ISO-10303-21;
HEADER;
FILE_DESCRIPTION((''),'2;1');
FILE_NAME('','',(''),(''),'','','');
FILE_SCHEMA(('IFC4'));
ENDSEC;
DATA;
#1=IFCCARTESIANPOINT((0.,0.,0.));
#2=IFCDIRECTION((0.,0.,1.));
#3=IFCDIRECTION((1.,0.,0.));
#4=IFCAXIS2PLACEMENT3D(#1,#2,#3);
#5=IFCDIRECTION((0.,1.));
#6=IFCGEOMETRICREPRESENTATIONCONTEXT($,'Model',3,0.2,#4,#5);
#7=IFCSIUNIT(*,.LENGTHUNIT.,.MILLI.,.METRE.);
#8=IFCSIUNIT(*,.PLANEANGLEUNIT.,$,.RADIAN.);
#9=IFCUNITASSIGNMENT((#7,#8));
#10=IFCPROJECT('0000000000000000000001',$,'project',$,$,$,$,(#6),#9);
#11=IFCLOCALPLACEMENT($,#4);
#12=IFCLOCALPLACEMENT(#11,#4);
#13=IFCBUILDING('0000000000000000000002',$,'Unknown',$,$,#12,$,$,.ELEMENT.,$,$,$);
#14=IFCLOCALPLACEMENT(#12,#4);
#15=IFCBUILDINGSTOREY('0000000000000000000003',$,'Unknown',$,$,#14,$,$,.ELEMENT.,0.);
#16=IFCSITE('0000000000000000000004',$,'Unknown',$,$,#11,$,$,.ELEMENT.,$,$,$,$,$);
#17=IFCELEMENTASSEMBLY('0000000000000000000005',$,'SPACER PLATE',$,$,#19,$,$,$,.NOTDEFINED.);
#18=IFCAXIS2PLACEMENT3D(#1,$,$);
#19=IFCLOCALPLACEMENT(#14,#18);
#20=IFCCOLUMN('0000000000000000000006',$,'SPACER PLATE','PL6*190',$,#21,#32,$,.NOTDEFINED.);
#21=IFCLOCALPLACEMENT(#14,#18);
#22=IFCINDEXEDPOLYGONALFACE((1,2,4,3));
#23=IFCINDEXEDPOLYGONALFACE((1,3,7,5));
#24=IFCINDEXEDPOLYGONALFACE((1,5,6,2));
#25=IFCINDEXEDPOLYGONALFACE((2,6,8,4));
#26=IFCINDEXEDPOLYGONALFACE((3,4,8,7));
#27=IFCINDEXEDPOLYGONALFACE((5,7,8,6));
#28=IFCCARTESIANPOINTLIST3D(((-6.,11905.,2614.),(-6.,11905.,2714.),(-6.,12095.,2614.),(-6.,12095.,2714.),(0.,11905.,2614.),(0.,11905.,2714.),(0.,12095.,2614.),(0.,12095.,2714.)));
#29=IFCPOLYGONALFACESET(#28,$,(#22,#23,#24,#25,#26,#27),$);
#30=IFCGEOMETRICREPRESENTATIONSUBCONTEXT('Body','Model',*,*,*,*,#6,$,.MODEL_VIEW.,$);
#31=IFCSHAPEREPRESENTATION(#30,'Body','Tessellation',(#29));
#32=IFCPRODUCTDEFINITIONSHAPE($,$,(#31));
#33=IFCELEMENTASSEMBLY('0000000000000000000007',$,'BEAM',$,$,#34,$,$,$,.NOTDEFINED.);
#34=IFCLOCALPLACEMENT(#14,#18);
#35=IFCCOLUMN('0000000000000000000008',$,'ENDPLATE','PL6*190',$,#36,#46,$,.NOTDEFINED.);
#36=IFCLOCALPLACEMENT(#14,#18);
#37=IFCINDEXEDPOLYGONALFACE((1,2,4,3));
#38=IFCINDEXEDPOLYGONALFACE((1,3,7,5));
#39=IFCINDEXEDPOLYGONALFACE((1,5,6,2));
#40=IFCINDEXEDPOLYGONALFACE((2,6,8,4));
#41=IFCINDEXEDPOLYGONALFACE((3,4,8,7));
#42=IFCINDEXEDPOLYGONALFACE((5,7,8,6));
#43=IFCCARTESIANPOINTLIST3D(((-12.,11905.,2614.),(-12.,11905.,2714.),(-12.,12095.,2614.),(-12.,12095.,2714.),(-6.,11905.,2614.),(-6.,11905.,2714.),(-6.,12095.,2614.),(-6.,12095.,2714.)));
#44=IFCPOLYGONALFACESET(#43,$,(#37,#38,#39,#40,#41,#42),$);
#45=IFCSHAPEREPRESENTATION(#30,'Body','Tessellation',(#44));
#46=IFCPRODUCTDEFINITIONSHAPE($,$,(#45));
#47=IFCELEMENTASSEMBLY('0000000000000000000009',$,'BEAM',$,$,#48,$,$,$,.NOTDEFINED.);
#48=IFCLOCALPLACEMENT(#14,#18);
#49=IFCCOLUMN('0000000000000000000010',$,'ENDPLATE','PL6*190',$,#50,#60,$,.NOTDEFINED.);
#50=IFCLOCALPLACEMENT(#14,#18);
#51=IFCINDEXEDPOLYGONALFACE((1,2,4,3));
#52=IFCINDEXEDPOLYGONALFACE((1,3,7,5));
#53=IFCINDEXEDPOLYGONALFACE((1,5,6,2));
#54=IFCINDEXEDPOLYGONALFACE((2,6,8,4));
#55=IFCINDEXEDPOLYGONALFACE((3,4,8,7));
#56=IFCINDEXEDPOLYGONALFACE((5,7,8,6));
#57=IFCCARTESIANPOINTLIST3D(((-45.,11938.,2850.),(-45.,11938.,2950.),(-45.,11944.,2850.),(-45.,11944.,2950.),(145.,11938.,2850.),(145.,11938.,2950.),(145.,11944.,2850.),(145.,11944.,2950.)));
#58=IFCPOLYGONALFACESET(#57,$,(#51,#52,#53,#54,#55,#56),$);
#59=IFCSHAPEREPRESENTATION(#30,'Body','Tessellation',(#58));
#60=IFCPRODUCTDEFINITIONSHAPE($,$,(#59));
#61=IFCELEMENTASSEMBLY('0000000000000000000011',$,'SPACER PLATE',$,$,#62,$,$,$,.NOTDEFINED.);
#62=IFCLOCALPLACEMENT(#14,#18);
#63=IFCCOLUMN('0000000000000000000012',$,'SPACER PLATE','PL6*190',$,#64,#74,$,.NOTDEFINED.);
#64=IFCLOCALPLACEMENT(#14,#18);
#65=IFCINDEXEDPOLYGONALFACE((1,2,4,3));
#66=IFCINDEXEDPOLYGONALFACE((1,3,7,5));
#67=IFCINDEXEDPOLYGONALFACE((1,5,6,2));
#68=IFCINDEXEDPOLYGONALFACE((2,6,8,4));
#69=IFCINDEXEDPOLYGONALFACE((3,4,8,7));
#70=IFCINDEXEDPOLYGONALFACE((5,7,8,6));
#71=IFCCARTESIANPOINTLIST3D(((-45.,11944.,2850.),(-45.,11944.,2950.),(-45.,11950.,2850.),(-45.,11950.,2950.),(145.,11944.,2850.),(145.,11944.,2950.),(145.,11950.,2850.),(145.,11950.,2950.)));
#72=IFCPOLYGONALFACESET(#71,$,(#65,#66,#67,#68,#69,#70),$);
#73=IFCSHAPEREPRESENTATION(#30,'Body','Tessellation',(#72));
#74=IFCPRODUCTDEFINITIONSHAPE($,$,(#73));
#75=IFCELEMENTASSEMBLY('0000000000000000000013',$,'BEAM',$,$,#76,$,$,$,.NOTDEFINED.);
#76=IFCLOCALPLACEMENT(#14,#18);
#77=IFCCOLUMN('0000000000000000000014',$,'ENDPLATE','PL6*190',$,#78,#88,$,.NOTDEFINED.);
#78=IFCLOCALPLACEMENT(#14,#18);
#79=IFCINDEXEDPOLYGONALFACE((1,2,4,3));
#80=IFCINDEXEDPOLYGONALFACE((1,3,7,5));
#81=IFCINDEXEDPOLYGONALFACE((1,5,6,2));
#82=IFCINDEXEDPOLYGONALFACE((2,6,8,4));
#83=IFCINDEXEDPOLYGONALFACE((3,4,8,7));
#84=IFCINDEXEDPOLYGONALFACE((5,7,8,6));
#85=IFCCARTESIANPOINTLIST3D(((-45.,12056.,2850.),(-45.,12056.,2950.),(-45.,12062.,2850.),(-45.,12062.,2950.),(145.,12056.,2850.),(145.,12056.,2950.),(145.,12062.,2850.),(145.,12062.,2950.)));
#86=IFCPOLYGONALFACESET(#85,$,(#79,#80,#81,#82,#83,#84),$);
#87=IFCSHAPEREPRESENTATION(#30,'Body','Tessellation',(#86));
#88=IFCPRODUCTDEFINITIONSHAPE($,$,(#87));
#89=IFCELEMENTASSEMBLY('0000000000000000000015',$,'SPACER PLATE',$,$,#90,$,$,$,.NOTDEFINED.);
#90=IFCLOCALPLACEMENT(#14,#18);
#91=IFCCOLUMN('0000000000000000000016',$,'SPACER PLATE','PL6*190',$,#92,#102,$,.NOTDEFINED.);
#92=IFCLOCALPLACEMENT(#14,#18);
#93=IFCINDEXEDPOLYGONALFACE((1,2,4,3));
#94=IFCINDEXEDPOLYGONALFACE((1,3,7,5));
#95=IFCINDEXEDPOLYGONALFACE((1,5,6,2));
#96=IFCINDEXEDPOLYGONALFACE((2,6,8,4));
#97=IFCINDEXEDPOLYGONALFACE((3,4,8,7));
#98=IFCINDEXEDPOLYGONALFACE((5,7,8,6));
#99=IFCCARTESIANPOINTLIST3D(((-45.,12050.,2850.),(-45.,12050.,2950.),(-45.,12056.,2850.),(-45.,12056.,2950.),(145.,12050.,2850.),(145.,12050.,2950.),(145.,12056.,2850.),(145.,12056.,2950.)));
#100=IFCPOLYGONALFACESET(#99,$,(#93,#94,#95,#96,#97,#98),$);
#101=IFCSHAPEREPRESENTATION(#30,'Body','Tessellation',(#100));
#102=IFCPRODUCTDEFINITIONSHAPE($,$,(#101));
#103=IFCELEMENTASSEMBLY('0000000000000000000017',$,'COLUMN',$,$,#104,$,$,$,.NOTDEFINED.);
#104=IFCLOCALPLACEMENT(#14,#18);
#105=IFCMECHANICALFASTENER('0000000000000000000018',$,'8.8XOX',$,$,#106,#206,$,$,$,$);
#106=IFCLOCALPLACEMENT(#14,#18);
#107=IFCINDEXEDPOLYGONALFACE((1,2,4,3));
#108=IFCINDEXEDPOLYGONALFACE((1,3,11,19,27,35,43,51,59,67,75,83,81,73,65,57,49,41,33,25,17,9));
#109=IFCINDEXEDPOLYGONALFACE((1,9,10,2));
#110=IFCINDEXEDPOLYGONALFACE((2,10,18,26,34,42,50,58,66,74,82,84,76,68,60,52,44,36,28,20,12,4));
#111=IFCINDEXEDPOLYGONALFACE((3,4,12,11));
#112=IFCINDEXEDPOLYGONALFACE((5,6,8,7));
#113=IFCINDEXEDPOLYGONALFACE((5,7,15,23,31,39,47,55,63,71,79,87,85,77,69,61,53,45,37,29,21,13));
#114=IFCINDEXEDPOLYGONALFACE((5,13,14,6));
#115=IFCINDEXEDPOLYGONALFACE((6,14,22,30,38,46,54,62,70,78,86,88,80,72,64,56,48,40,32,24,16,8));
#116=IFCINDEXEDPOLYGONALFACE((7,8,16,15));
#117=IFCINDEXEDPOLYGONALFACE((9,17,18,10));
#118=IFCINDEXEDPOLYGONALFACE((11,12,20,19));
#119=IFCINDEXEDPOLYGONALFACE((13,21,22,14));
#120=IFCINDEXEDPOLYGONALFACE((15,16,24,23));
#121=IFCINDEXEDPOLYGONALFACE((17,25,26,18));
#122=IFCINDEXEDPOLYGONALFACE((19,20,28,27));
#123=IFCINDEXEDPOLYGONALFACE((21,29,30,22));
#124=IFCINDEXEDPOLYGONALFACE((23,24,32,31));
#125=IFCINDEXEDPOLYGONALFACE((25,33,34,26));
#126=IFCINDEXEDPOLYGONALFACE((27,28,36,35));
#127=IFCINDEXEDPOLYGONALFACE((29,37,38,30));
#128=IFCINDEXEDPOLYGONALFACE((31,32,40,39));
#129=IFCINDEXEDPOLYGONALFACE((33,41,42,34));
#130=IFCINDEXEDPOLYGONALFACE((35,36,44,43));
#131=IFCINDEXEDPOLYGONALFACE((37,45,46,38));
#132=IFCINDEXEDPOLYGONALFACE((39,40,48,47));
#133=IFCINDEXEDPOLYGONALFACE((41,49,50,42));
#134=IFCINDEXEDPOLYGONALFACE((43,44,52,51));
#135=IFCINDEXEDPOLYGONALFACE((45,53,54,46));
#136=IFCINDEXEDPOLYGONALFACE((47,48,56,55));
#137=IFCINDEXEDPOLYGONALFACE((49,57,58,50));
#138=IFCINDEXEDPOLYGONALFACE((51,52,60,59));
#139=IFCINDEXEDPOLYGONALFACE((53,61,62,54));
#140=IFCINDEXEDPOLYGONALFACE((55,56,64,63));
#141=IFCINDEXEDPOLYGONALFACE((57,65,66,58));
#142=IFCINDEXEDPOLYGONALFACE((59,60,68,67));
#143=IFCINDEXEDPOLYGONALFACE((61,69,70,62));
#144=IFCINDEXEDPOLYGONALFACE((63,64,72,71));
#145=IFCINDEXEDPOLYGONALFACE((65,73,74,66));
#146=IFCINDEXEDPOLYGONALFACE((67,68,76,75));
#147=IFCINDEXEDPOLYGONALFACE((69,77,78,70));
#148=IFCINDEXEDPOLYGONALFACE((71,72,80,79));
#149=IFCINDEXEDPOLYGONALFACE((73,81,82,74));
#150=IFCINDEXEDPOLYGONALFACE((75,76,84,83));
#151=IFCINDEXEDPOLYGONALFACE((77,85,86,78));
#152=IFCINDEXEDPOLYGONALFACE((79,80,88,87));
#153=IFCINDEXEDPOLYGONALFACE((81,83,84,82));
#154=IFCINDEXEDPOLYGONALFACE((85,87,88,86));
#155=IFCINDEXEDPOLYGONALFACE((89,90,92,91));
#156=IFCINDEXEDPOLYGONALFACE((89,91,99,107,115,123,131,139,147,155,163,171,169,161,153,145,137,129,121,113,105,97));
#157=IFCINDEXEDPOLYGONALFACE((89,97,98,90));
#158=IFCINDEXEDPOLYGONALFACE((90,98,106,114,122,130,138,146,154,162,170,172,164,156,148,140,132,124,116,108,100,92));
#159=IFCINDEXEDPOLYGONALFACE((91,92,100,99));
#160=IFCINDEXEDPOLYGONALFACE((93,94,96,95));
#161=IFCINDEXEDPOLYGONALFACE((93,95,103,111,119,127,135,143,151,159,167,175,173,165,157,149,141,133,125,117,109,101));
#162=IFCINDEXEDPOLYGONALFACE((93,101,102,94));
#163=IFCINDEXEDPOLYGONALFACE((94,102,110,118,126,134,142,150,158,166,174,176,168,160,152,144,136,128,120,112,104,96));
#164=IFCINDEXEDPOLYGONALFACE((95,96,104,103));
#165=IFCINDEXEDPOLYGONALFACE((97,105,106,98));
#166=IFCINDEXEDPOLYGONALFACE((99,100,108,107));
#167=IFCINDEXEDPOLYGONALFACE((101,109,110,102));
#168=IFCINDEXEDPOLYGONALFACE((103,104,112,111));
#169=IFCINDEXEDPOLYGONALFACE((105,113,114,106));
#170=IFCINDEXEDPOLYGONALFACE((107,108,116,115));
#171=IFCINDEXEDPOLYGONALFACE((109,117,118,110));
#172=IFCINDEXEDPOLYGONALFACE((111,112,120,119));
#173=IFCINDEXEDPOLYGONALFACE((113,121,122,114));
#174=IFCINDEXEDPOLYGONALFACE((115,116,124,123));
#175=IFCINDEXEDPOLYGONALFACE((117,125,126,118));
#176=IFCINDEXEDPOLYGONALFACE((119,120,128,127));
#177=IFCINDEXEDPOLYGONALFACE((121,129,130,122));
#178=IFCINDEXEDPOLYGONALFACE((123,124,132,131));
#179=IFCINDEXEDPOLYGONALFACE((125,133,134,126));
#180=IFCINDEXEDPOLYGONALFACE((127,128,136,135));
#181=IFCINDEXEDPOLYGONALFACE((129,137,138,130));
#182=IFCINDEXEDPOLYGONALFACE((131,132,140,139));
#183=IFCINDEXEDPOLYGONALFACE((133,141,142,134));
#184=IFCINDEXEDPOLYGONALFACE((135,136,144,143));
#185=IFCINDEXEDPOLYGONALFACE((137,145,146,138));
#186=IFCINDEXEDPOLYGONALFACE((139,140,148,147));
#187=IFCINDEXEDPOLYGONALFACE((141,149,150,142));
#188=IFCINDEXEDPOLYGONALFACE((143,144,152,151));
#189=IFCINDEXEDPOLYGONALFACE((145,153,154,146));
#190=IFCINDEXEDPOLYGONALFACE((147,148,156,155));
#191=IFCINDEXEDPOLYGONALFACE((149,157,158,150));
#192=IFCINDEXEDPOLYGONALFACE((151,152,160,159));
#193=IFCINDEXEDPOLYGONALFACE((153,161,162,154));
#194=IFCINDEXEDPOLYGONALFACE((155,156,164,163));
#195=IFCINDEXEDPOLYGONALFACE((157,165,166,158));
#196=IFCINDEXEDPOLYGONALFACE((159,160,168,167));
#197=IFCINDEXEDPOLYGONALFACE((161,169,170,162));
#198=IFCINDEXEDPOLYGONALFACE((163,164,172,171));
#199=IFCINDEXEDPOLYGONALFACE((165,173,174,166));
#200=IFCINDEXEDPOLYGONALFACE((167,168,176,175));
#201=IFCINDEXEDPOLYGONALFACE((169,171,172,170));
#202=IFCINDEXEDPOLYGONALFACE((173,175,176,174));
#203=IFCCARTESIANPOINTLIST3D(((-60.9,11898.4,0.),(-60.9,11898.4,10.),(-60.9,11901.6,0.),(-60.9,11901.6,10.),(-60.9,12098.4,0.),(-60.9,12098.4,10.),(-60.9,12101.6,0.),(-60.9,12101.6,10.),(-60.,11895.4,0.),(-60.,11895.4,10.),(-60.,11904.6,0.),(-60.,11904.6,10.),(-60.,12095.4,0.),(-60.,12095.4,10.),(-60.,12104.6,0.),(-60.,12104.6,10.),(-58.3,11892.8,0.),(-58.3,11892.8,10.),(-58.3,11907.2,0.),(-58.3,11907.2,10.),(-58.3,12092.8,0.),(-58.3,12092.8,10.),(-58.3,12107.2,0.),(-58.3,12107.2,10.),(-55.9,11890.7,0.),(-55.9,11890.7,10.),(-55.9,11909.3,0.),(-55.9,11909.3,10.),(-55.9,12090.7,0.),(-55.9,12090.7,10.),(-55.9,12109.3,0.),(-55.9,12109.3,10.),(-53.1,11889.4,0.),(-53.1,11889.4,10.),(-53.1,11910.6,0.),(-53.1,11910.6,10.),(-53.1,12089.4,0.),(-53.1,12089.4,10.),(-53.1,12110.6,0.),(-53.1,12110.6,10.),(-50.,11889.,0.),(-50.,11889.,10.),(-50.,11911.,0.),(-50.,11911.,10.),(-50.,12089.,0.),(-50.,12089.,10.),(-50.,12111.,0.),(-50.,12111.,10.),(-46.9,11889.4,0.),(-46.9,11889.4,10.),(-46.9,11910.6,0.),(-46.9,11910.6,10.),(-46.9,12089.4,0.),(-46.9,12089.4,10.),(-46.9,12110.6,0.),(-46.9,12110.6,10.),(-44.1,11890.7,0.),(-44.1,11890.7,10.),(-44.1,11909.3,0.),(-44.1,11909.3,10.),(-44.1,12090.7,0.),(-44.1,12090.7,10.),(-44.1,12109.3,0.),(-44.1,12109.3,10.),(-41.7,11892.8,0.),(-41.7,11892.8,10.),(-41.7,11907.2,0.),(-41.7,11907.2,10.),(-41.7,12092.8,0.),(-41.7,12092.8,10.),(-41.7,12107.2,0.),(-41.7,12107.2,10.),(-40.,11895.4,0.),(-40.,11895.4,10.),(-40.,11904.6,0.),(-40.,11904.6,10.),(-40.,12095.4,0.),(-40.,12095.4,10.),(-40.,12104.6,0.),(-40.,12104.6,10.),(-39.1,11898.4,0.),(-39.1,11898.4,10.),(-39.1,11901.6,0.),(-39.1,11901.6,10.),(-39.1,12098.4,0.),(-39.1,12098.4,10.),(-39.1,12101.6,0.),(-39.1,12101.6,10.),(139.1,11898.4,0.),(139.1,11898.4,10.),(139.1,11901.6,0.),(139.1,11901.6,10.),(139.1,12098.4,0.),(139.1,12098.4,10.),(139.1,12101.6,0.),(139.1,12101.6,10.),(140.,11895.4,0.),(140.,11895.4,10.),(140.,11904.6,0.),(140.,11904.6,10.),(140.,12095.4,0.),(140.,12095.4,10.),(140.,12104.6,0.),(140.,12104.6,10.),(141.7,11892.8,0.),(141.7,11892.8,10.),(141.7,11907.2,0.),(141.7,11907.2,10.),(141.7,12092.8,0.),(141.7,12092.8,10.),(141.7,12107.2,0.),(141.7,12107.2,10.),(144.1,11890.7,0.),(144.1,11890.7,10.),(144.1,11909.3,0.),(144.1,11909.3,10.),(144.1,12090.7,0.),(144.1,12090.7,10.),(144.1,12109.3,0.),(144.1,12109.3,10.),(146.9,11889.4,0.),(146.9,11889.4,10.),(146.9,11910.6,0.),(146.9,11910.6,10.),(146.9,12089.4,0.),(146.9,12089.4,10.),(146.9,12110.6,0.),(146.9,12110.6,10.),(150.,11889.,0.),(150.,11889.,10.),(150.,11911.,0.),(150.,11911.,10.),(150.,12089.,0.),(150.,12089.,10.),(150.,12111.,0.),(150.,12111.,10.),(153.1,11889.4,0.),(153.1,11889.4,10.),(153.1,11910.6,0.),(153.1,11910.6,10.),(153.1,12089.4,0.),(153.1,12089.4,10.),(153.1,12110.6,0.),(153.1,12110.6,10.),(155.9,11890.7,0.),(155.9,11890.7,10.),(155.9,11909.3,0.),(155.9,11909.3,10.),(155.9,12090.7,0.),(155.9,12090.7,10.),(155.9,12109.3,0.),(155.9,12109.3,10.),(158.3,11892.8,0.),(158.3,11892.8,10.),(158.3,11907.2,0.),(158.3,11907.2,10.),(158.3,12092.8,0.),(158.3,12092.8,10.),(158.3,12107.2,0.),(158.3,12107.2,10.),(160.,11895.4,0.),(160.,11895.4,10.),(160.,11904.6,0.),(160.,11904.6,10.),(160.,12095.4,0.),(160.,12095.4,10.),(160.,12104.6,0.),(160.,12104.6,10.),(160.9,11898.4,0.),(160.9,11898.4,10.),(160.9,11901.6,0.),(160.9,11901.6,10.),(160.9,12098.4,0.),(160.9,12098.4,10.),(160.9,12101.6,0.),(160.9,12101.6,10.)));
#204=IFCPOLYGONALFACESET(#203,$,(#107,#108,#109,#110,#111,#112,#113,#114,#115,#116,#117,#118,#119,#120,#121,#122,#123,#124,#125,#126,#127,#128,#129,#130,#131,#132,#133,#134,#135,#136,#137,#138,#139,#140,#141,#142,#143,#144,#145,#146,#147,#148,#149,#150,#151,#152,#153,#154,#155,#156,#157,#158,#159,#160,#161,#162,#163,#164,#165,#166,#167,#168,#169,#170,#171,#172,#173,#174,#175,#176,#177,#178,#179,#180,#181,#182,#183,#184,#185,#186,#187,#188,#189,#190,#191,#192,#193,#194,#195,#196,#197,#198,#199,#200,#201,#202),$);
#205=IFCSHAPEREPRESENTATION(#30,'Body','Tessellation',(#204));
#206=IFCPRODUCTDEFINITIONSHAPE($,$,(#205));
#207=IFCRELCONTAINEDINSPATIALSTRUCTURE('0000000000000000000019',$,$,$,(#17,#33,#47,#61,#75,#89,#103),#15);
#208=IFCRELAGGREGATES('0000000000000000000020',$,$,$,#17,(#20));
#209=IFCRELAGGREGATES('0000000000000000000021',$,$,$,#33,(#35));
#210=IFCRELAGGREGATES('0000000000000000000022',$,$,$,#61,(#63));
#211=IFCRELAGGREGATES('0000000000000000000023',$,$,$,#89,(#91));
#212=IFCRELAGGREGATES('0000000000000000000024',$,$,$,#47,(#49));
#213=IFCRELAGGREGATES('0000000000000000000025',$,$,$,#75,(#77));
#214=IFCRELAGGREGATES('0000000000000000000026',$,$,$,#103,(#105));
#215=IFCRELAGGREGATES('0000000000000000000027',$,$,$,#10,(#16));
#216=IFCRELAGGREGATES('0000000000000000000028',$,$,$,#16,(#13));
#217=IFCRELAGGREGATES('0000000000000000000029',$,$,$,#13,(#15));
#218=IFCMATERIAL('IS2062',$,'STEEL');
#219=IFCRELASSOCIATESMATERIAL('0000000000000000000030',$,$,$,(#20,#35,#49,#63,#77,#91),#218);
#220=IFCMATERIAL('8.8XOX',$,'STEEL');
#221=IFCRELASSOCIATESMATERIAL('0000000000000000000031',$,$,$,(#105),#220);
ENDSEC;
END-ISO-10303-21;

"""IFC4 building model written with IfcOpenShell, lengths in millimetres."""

from ifc_helpers import new_model, si_unit, direction, frame, origin_with_axes, place, context, subcontext, project, spatial, line, arc, indexed_curve, outline, extrude, source, transform, mapped, material, element, aggregate, save


model = new_model("IFC4")

# Units and contexts
model_context = context("Model", 3, precision=0.2, world=origin_with_axes(), true_north=direction((0.0, 1.0)))
body_context = subcontext(model_context, "Body", "Model", "MODEL_VIEW")
ifc_project = project(units=[si_unit("LENGTHUNIT", "METRE", prefix="MILLI"), si_unit("PLANEANGLEUNIT", "RADIAN")], contexts=[model_context])

# Site, building, storey
site_placement = place(None, origin_with_axes())
site = spatial("IfcSite", under=ifc_project, at=site_placement, Name="Unknown", CompositionType="ELEMENT")
building_placement = place(site_placement, origin_with_axes())
building = spatial("IfcBuilding", under=site, at=building_placement, Name="Unknown", CompositionType="ELEMENT")
storey_placement = place(building_placement, origin_with_axes())
storey = spatial("IfcBuildingStorey", under=building, at=storey_placement, Name="Unknown", CompositionType="ELEMENT", Elevation=0.0)

# Element assemblies, columns
assembly_1_placement = place(storey_placement, frame((-3.0, 12000.0, 2614.0), z_axis=(-1.0, 0.0, 0.0), x_axis=(0.0, 0.0, 1.0)))
assembly_1 = element("IfcElementAssembly", 1, at=assembly_1_placement, inside=storey, Name="SPACER PLATE", PredefinedType="NOTDEFINED")
ifc_material_1 = material(Name="IS2062", Category="STEEL")
column_1_placement = place(assembly_1_placement, origin_with_axes())
column_1 = element("IfcColumn", 2, at=column_1_placement, material=ifc_material_1, Name="SPACER PLATE", Description="PL6*190", PredefinedType="NOTDEFINED", context=body_context, shape_type="SolidModel", body=[
    extrude(outline(indexed_curve([(-3.0, -95.0), (3.0, -95.0), (3.0, 95.0), (-3.0, 95.0)], segments=[line(1, 2, 3, 4, 1)])), frame((0.0, 0.0, 0.0), z_axis=(-1.0, 0.0, 0.0), x_axis=(0.0, 0.0, 1.0)), (0.0, 0.0, -1.0), 100.0),
])
aggregate(assembly_1, [column_1])
assembly_2_placement = place(storey_placement, frame((-1505.9, 12000.0, 2664.0), z_axis=(0.0, -1.0, 0.0), x_axis=(1.0, 0.0, 0.0)))
assembly_2 = element("IfcElementAssembly", 3, at=assembly_2_placement, inside=storey, Name="BEAM", PredefinedType="NOTDEFINED")
column_2_placement = place(assembly_2_placement, frame((1496.9, -50.0, 0.0), z_axis=(-1.0, 0.0, 0.0), x_axis=(0.0, 1.0, 0.0)))
column_2 = element("IfcColumn", 4, at=column_2_placement, material=ifc_material_1, Name="ENDPLATE", Description="PL6*190", PredefinedType="NOTDEFINED", context=body_context, shape_type="SolidModel", body=[
    extrude(outline(indexed_curve([(-3.0, -95.0), (3.0, -95.0), (3.0, 95.0), (-3.0, 95.0)], segments=[line(1, 2, 3, 4, 1)])), frame((0.0, 0.0, 0.0), z_axis=(-1.0, 0.0, 0.0), x_axis=(0.0, 0.0, 1.0)), (0.0, 0.0, -1.0), 100.0),
])
aggregate(assembly_2, [column_2])
assembly_3_placement = place(storey_placement, frame((50.0, 12000.0, 2900.0), z_axis=(-1.0, 0.0, 0.0), x_axis=(0.0, -1.0, 0.0)))
assembly_3 = element("IfcElementAssembly", 5, at=assembly_3_placement, inside=storey, Name="BEAM", PredefinedType="NOTDEFINED")
column_3_placement = place(assembly_3_placement, frame((59.0, -50.0, 0.0), z_axis=(1.0, 0.0, 0.0), x_axis=(0.0, 1.0, 0.0)))
column_3 = element("IfcColumn", 6, at=column_3_placement, material=ifc_material_1, Name="ENDPLATE", Description="PL6*190", PredefinedType="NOTDEFINED", context=body_context, shape_type="SolidModel", body=[
    extrude(outline(indexed_curve([(-3.0, -95.0), (3.0, -95.0), (3.0, 95.0), (-3.0, 95.0)], segments=[line(1, 2, 3, 4, 1)])), frame((0.0, 0.0, 0.0), z_axis=(-1.0, 0.0, 0.0), x_axis=(0.0, 0.0, 1.0)), (0.0, 0.0, -1.0), 100.0),
])
assembly_4_placement = place(storey_placement, frame((50.0, 11947.0, 2850.0), z_axis=(0.0, -1.0, 0.0), x_axis=(0.0, 0.0, 1.0)))
assembly_4 = element("IfcElementAssembly", 7, at=assembly_4_placement, inside=storey, Name="SPACER PLATE", PredefinedType="NOTDEFINED")
column_4_placement = place(assembly_4_placement, origin_with_axes())
column_4 = element("IfcColumn", 8, at=column_4_placement, material=ifc_material_1, Name="SPACER PLATE", Description="PL6*190", PredefinedType="NOTDEFINED", context=body_context, shape_type="SolidModel", body=[
    extrude(outline(indexed_curve([(-3.0, -95.0), (3.0, -95.0), (3.0, 95.0), (-3.0, 95.0)], segments=[line(1, 2, 3, 4, 1)])), frame((0.0, 0.0, 0.0), z_axis=(-1.0, 0.0, 0.0), x_axis=(0.0, 0.0, 1.0)), (0.0, 0.0, -1.0), 100.0),
])
aggregate(assembly_4, [column_4])
assembly_5_placement = place(storey_placement, frame((50.0, 18000.0, 2900.0), z_axis=(-1.0, 0.0, 0.0), x_axis=(0.0, -1.0, 0.0)))
assembly_5 = element("IfcElementAssembly", 9, at=assembly_5_placement, inside=storey, Name="BEAM", PredefinedType="NOTDEFINED")
column_5_placement = place(assembly_5_placement, frame((5941.0, -50.0, 0.0), z_axis=(-1.0, 0.0, 0.0), x_axis=(0.0, 1.0, 0.0)))
column_5 = element("IfcColumn", 10, at=column_5_placement, material=ifc_material_1, Name="ENDPLATE", Description="PL6*190", PredefinedType="NOTDEFINED", context=body_context, shape_type="SolidModel", body=[
    extrude(outline(indexed_curve([(-3.0, -95.0), (3.0, -95.0), (3.0, 95.0), (-3.0, 95.0)], segments=[line(1, 2, 3, 4, 1)])), frame((0.0, 0.0, 0.0), z_axis=(-1.0, 0.0, 0.0), x_axis=(0.0, 0.0, 1.0)), (0.0, 0.0, -1.0), 100.0),
])
assembly_6_placement = place(storey_placement, frame((50.0, 12053.0, 2850.0), z_axis=(0.0, 1.0, 0.0), x_axis=(0.0, 0.0, 1.0)))
assembly_6 = element("IfcElementAssembly", 11, at=assembly_6_placement, inside=storey, Name="SPACER PLATE", PredefinedType="NOTDEFINED")
column_6_placement = place(assembly_6_placement, origin_with_axes())
column_6 = element("IfcColumn", 12, at=column_6_placement, material=ifc_material_1, Name="SPACER PLATE", Description="PL6*190", PredefinedType="NOTDEFINED", context=body_context, shape_type="SolidModel", body=[
    extrude(outline(indexed_curve([(-3.0, -95.0), (3.0, -95.0), (3.0, 95.0), (-3.0, 95.0)], segments=[line(1, 2, 3, 4, 1)])), frame((0.0, 0.0, 0.0), z_axis=(-1.0, 0.0, 0.0), x_axis=(0.0, 0.0, 1.0)), (0.0, 0.0, -1.0), 100.0),
])
aggregate(assembly_6, [column_6])

# Shared definitions
ifc_material_2 = material(Name="8.8XOX", Category="STEEL")
aggregate(assembly_3, [column_3])
aggregate(assembly_5, [column_5])

# Element assembly, mechanical fastener
assembly_7_placement = place(storey_placement, frame((50.0, 12000.0, 0.0), z_axis=(0.0, 1.0, 0.0), x_axis=(0.0, 0.0, 1.0)))
assembly_7 = element("IfcElementAssembly", 13, at=assembly_7_placement, inside=storey, Name="COLUMN", PredefinedType="NOTDEFINED")
shared_shape_1 = source(origin_with_axes(), body_context, "Body", "SweptSolid", [
    extrude(outline(indexed_curve([(11.0, 0.0), (0.0, 11.0), (-11.0, 0.0), (0.0, -11.0)], segments=[arc(1, 2, 3), arc(3, 4, 1)])), frame((0.0, 0.0, 0.0), z_axis=(0.0, 0.0, -1.0), x_axis=(0.0, 1.0, 0.0)), (0.0, 0.0, 1.0), 10.0),
])
mechanical_fastener_1_placement = place(assembly_7_placement, frame((10.0, 50.0, 0.0), z_axis=(1.0, 0.0, 0.0), x_axis=(0.0, -1.0, 0.0)))
mechanical_fastener_1 = element("IfcMechanicalFastener", 14, at=mechanical_fastener_1_placement, material=ifc_material_2, Name="8.8XOX", context=body_context, shape_type="MappedRepresentation", body=[
    mapped(shared_shape_1, transform((-50.0, 100.0, 0.0))),
    mapped(shared_shape_1, transform((-50.0, -100.0, 0.0))),
    mapped(shared_shape_1, transform((150.0, 100.0, 0.0))),
    mapped(shared_shape_1, transform((150.0, -100.0, 0.0))),
])
aggregate(assembly_7, [mechanical_fastener_1])

save(model, "model.ifc")
